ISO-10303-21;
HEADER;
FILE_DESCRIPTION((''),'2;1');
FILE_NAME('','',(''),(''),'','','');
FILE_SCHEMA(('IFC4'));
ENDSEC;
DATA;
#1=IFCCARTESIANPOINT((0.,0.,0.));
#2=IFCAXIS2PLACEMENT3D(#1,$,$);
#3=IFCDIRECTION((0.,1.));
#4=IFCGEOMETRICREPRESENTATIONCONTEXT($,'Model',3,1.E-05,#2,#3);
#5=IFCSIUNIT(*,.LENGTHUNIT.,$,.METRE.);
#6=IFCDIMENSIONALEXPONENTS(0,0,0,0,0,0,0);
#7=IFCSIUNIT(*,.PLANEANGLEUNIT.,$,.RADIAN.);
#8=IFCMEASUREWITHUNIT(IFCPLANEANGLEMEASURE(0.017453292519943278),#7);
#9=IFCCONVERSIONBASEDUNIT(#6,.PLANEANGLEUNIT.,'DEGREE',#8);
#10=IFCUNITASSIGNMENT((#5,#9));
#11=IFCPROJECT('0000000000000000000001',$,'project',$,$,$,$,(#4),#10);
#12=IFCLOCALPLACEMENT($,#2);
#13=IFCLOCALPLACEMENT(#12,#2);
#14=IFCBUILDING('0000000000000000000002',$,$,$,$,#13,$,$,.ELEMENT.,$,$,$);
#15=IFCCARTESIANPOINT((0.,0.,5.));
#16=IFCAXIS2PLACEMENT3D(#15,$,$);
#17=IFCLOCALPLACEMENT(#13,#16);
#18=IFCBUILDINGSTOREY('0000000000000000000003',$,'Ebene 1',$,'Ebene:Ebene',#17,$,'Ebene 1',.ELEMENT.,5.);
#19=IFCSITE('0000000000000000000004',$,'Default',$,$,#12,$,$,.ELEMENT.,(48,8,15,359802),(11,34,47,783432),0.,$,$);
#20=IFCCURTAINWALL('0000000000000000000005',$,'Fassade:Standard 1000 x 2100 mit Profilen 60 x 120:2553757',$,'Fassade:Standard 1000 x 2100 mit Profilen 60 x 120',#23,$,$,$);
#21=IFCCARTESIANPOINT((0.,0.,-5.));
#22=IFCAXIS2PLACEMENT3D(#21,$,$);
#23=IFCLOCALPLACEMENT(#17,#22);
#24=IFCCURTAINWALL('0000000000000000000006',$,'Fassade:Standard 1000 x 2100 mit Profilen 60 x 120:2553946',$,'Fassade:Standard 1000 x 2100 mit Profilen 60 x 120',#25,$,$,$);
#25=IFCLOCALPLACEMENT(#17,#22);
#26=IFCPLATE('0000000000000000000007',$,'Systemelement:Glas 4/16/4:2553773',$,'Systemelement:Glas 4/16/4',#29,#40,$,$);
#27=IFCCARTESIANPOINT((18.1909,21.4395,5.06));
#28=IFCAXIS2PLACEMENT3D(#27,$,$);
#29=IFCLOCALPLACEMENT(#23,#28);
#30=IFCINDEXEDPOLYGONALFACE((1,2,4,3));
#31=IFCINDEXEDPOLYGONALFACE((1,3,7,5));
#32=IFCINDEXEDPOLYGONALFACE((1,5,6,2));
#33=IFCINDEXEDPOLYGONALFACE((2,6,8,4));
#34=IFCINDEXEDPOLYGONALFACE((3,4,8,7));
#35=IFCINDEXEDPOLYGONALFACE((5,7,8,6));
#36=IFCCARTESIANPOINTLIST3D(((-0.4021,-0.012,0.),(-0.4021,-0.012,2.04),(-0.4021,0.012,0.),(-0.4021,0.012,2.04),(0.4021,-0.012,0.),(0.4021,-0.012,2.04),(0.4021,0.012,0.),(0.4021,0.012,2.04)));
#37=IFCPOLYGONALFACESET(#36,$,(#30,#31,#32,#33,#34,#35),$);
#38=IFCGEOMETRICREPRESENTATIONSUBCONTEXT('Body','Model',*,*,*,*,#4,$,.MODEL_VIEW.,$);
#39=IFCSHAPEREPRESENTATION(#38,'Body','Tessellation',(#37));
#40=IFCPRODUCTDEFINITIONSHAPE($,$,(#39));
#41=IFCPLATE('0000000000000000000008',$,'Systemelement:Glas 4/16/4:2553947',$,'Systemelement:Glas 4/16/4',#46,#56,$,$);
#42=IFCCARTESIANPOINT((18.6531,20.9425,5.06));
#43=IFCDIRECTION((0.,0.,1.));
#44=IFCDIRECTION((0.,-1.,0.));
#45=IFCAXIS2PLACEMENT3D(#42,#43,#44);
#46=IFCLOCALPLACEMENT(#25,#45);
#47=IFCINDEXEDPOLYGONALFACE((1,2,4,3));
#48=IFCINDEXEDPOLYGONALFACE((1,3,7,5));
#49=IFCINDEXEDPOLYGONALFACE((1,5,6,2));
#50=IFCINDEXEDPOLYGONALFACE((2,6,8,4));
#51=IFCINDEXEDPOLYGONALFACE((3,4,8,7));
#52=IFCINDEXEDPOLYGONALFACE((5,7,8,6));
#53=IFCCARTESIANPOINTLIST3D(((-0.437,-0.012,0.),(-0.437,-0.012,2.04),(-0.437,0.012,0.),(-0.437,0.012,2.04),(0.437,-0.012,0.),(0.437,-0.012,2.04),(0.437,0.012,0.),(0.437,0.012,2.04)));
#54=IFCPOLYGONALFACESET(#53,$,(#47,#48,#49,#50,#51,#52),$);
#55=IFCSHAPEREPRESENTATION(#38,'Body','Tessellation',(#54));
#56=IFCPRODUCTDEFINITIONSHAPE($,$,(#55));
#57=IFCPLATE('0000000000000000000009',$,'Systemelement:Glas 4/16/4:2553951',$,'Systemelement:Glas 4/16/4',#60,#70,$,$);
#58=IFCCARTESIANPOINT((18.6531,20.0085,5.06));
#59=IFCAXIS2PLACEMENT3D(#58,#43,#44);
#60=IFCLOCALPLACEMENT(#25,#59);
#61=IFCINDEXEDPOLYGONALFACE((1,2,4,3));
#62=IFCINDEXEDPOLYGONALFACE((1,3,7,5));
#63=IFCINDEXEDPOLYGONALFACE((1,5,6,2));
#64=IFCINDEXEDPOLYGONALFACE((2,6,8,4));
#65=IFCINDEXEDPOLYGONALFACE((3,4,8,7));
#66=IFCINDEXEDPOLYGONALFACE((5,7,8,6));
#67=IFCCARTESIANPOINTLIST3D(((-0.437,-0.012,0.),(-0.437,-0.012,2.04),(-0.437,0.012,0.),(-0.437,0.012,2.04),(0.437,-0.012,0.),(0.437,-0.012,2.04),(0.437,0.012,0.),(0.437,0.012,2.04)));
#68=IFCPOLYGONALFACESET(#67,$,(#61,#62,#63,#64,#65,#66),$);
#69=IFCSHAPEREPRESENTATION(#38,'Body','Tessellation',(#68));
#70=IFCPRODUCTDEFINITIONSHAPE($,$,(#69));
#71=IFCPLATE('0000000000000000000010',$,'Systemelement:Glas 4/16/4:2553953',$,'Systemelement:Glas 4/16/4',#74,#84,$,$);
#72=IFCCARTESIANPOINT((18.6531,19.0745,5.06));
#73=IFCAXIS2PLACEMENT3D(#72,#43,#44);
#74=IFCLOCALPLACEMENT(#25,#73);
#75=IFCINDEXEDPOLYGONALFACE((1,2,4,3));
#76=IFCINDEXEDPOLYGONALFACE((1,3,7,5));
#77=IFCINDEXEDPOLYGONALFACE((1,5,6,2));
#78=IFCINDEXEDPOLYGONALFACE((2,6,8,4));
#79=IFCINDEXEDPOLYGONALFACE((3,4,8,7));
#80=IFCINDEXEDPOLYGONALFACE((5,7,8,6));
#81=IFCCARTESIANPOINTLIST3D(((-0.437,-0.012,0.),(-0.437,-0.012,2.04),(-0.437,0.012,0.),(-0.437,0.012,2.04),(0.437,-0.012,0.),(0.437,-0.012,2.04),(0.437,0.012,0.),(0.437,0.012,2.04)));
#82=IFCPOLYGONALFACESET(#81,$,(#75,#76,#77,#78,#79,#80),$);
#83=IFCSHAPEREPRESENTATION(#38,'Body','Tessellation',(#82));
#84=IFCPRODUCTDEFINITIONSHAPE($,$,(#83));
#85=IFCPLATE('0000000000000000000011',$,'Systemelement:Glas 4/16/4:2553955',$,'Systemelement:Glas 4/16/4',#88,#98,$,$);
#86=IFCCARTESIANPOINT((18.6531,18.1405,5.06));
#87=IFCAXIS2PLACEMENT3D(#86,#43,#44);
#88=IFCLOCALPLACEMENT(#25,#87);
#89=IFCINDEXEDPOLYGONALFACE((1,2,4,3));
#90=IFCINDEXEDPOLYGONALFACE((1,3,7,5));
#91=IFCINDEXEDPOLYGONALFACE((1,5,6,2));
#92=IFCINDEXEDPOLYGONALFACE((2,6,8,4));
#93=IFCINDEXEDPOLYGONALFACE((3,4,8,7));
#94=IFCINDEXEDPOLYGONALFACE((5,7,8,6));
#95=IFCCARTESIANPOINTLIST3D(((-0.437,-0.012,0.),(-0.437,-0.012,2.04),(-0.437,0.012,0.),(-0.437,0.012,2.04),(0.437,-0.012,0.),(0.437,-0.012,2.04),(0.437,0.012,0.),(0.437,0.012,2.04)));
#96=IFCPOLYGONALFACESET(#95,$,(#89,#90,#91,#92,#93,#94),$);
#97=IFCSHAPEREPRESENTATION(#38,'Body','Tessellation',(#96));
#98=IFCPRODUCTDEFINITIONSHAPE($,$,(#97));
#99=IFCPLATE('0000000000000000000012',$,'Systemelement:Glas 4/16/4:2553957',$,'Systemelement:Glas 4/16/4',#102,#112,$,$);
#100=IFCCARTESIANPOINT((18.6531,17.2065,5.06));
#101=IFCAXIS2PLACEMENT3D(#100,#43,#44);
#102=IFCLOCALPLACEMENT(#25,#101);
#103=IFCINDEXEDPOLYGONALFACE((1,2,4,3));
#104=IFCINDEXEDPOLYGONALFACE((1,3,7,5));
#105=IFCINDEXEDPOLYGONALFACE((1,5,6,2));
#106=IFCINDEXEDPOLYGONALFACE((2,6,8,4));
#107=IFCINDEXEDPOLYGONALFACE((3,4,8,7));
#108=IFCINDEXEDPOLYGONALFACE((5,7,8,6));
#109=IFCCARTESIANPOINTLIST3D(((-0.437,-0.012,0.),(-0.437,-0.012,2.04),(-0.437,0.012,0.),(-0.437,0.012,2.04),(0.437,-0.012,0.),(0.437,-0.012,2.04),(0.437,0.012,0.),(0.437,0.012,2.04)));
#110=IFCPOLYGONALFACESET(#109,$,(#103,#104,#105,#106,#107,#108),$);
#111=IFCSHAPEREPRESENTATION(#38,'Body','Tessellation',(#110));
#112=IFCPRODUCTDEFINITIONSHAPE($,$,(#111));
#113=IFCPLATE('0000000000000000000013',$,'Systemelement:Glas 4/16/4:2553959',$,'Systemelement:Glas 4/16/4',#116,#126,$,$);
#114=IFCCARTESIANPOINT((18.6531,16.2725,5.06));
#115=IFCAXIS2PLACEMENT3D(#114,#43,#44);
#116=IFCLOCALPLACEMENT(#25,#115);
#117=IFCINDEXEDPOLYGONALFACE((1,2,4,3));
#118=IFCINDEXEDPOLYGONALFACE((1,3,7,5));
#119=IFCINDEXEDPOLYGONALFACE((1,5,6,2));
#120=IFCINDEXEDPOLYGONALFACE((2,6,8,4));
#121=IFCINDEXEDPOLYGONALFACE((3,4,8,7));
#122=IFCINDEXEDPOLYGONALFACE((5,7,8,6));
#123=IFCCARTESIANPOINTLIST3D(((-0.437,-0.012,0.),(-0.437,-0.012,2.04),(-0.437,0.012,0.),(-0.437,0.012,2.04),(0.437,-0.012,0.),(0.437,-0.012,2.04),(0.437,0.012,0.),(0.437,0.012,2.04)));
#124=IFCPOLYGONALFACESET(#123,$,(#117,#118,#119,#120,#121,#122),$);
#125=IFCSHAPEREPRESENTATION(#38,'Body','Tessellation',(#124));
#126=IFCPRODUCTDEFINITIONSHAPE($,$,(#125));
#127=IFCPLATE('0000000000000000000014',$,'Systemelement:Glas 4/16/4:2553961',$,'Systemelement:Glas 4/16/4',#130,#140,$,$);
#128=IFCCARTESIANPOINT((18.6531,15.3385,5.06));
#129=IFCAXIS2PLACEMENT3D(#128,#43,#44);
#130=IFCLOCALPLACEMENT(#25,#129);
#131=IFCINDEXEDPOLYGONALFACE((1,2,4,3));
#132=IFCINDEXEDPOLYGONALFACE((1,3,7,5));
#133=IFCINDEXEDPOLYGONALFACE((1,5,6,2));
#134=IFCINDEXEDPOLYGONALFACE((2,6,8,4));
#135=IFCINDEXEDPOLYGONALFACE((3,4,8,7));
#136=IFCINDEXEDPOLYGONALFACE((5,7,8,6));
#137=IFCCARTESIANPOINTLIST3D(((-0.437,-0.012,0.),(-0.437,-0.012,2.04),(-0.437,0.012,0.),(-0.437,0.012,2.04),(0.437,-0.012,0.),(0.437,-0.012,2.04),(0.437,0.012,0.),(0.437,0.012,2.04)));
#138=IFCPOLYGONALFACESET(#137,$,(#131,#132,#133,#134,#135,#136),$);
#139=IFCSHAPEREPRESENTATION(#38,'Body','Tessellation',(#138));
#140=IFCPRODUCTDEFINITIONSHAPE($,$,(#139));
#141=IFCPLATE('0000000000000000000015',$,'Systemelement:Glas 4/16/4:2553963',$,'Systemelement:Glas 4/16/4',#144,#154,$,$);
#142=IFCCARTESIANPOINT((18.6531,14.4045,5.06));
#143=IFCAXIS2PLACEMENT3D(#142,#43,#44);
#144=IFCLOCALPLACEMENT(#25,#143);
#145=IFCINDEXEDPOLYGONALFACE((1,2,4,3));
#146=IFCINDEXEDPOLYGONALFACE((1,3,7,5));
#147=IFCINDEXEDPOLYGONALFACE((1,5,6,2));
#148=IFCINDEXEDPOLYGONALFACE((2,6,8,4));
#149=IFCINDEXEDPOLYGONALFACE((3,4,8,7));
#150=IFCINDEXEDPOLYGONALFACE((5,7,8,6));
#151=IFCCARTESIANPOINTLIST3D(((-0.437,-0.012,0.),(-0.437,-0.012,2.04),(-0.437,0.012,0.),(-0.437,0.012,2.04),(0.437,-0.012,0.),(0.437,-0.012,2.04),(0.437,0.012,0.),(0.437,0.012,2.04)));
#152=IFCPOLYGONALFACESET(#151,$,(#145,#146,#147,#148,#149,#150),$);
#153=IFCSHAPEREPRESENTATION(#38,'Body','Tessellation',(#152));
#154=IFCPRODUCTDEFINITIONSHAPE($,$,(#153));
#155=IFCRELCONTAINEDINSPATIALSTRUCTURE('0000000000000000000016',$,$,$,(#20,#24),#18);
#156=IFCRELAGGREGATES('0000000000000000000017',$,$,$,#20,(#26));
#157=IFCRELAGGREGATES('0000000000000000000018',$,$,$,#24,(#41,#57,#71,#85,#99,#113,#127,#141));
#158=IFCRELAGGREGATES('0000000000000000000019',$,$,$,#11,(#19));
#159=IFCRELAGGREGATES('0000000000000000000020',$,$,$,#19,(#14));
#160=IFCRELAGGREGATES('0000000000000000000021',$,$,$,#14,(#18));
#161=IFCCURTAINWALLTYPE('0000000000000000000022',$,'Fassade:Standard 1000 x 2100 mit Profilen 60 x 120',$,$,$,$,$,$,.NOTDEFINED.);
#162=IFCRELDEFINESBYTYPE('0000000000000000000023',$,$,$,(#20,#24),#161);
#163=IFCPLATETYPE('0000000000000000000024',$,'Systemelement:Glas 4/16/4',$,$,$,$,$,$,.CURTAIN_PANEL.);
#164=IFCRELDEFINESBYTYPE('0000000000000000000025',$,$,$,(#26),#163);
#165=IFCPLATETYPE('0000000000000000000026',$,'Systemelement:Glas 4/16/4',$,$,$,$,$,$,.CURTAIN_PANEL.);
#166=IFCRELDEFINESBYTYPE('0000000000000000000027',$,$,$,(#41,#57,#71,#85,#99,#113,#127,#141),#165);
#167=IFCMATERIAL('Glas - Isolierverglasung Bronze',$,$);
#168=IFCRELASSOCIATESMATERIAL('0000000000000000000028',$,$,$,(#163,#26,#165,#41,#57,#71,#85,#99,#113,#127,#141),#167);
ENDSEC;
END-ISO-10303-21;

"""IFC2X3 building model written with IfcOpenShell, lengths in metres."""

from ifc_helpers import new_model, entity, si_unit, converted_unit, direction, frame, origin, origin_2d_with_axis, place, context, subcontext, project, spatial, rectangle, extrude, source, transform, mapped, material, type_object, type_shapes, element, aggregate, save


model = new_model("IFC2X3")

# Units and contexts
model_context = context("Model", 3, precision=1e-05, world=origin(), true_north=direction((0.0, 1.0)))
body_context = subcontext(model_context, "Body", "Model", "MODEL_VIEW")
ifc_project = project(units=[si_unit("LENGTHUNIT", "METRE"), converted_unit("PLANEANGLEUNIT", "DEGREE", entity("IfcPlaneAngleMeasure", 0.017453292519943278), si_unit("PLANEANGLEUNIT", "RADIAN"), dimensions=[0, 0, 0, 0, 0, 0, 0])], contexts=[model_context])

# Site, building, storey
site_placement = place(None, origin())
site = spatial("IfcSite", under=ifc_project, at=site_placement, Name="Default", CompositionType="ELEMENT", RefLatitude=(48, 8, 15, 359802), RefLongitude=(11, 34, 47, 783432), RefElevation=0.0)
building_placement = place(site_placement, origin())
building = spatial("IfcBuilding", under=site, at=building_placement, CompositionType="ELEMENT")
storey_placement = place(building_placement, frame((0.0, 0.0, 5.0)))
storey = spatial("IfcBuildingStorey", under=building, at=storey_placement, Name="Ebene 1", ObjectType="Ebene:Ebene", LongName="Ebene 1", CompositionType="ELEMENT", Elevation=5.0)

# Curtain walls
curtain_wall_type = type_object("IfcCurtainWallType", Name="Fassade:Standard 1000 x 2100 mit Profilen 60 x 120", PredefinedType="NOTDEFINED")
curtain_wall_1_placement = place(storey_placement, frame((0.0, 0.0, -5.0)))
curtain_wall_1 = element("IfcCurtainWall", 1, at=curtain_wall_1_placement, inside=storey, type_object=curtain_wall_type, Name="Fassade:Standard 1000 x 2100 mit Profilen 60 x 120:2553757", ObjectType="Fassade:Standard 1000 x 2100 mit Profilen 60 x 120")
curtain_wall_2_placement = place(storey_placement, frame((0.0, 0.0, -5.0)))
curtain_wall_2 = element("IfcCurtainWall", 2, at=curtain_wall_2_placement, inside=storey, type_object=curtain_wall_type, Name="Fassade:Standard 1000 x 2100 mit Profilen 60 x 120:2553946", ObjectType="Fassade:Standard 1000 x 2100 mit Profilen 60 x 120")

# Plates
ifc_material_1 = material(Name="Glas - Isolierverglasung Bronze")
plate_type_1 = type_object("IfcPlateType", Name="Systemelement:Glas 4/16/4", PredefinedType="CURTAIN_PANEL", material=ifc_material_1)
shared_shape_1 = source(origin(), body_context, "Body", "SweptSolid", [
    extrude(rectangle(XDim=0.024, YDim=0.8043, at=origin_2d_with_axis()), frame((0.0, 0.0, 0.0), z_axis=(0.0, 0.0, 1.0), x_axis=(0.0, 1.0, 0.0)), (0.0, 0.0, 1.0), 2.04),
])
type_shapes(plate_type_1, [shared_shape_1])
plate_1_placement = place(curtain_wall_1_placement, frame((18.1909, 21.4395, 5.06)))
plate_1 = element("IfcPlate", 3, at=plate_1_placement, type_object=plate_type_1, material=ifc_material_1, Name="Systemelement:Glas 4/16/4:2553773", ObjectType="Systemelement:Glas 4/16/4", context=body_context, shape_type="MappedRepresentation", body=[
    mapped(shared_shape_1, transform((0.0, 0.0, 0.0), scale=1.0)),
])
aggregate(curtain_wall_1, [plate_1])
plate_type_2 = type_object("IfcPlateType", Name="Systemelement:Glas 4/16/4", PredefinedType="CURTAIN_PANEL", material=ifc_material_1)
shared_shape_2 = source(origin(), body_context, "Body", "SweptSolid", [
    extrude(rectangle(XDim=0.024, YDim=0.874, at=origin_2d_with_axis()), frame((0.0, 0.0, 0.0), z_axis=(0.0, 0.0, 1.0), x_axis=(0.0, 1.0, 0.0)), (0.0, 0.0, 1.0), 2.04),
])
type_shapes(plate_type_2, [shared_shape_2])
plate_2_placement = place(curtain_wall_2_placement, frame((18.6531, 20.9425, 5.06), z_axis=(0.0, 0.0, 1.0), x_axis=(0.0, -1.0, 0.0)))
plate_2 = element("IfcPlate", 4, at=plate_2_placement, type_object=plate_type_2, material=ifc_material_1, Name="Systemelement:Glas 4/16/4:2553947", ObjectType="Systemelement:Glas 4/16/4", context=body_context, shape_type="MappedRepresentation", body=[
    mapped(shared_shape_2, transform((0.0, 0.0, 0.0), scale=1.0)),
])
plate_3_placement = place(curtain_wall_2_placement, frame((18.6531, 20.0085, 5.06), z_axis=(0.0, 0.0, 1.0), x_axis=(0.0, -1.0, 0.0)))
plate_3 = element("IfcPlate", 5, at=plate_3_placement, type_object=plate_type_2, material=ifc_material_1, Name="Systemelement:Glas 4/16/4:2553951", ObjectType="Systemelement:Glas 4/16/4", context=body_context, shape_type="MappedRepresentation", body=[
    mapped(shared_shape_2, transform((0.0, 0.0, 0.0), scale=1.0)),
])
plate_4_placement = place(curtain_wall_2_placement, frame((18.6531, 19.0745, 5.06), z_axis=(0.0, 0.0, 1.0), x_axis=(0.0, -1.0, 0.0)))
plate_4 = element("IfcPlate", 6, at=plate_4_placement, type_object=plate_type_2, material=ifc_material_1, Name="Systemelement:Glas 4/16/4:2553953", ObjectType="Systemelement:Glas 4/16/4", context=body_context, shape_type="MappedRepresentation", body=[
    mapped(shared_shape_2, transform((0.0, 0.0, 0.0), scale=1.0)),
])
plate_5_placement = place(curtain_wall_2_placement, frame((18.6531, 18.1405, 5.06), z_axis=(0.0, 0.0, 1.0), x_axis=(0.0, -1.0, 0.0)))
plate_5 = element("IfcPlate", 7, at=plate_5_placement, type_object=plate_type_2, material=ifc_material_1, Name="Systemelement:Glas 4/16/4:2553955", ObjectType="Systemelement:Glas 4/16/4", context=body_context, shape_type="MappedRepresentation", body=[
    mapped(shared_shape_2, transform((0.0, 0.0, 0.0), scale=1.0)),
])
plate_6_placement = place(curtain_wall_2_placement, frame((18.6531, 17.2065, 5.06), z_axis=(0.0, 0.0, 1.0), x_axis=(0.0, -1.0, 0.0)))
plate_6 = element("IfcPlate", 8, at=plate_6_placement, type_object=plate_type_2, material=ifc_material_1, Name="Systemelement:Glas 4/16/4:2553957", ObjectType="Systemelement:Glas 4/16/4", context=body_context, shape_type="MappedRepresentation", body=[
    mapped(shared_shape_2, transform((0.0, 0.0, 0.0), scale=1.0)),
])
plate_7_placement = place(curtain_wall_2_placement, frame((18.6531, 16.2725, 5.06), z_axis=(0.0, 0.0, 1.0), x_axis=(0.0, -1.0, 0.0)))
plate_7 = element("IfcPlate", 9, at=plate_7_placement, type_object=plate_type_2, material=ifc_material_1, Name="Systemelement:Glas 4/16/4:2553959", ObjectType="Systemelement:Glas 4/16/4", context=body_context, shape_type="MappedRepresentation", body=[
    mapped(shared_shape_2, transform((0.0, 0.0, 0.0), scale=1.0)),
])
plate_8_placement = place(curtain_wall_2_placement, frame((18.6531, 15.3385, 5.06), z_axis=(0.0, 0.0, 1.0), x_axis=(0.0, -1.0, 0.0)))
plate_8 = element("IfcPlate", 10, at=plate_8_placement, type_object=plate_type_2, material=ifc_material_1, Name="Systemelement:Glas 4/16/4:2553961", ObjectType="Systemelement:Glas 4/16/4", context=body_context, shape_type="MappedRepresentation", body=[
    mapped(shared_shape_2, transform((0.0, 0.0, 0.0), scale=1.0)),
])
plate_9_placement = place(curtain_wall_2_placement, frame((18.6531, 14.4045, 5.06), z_axis=(0.0, 0.0, 1.0), x_axis=(0.0, -1.0, 0.0)))
plate_9 = element("IfcPlate", 11, at=plate_9_placement, type_object=plate_type_2, material=ifc_material_1, Name="Systemelement:Glas 4/16/4:2553963", ObjectType="Systemelement:Glas 4/16/4", context=body_context, shape_type="MappedRepresentation", body=[
    mapped(shared_shape_2, transform((0.0, 0.0, 0.0), scale=1.0)),
])
aggregate(curtain_wall_2, [plate_2, plate_3, plate_4, plate_5, plate_6, plate_7, plate_8, plate_9])

save(model, "model.ifc")
